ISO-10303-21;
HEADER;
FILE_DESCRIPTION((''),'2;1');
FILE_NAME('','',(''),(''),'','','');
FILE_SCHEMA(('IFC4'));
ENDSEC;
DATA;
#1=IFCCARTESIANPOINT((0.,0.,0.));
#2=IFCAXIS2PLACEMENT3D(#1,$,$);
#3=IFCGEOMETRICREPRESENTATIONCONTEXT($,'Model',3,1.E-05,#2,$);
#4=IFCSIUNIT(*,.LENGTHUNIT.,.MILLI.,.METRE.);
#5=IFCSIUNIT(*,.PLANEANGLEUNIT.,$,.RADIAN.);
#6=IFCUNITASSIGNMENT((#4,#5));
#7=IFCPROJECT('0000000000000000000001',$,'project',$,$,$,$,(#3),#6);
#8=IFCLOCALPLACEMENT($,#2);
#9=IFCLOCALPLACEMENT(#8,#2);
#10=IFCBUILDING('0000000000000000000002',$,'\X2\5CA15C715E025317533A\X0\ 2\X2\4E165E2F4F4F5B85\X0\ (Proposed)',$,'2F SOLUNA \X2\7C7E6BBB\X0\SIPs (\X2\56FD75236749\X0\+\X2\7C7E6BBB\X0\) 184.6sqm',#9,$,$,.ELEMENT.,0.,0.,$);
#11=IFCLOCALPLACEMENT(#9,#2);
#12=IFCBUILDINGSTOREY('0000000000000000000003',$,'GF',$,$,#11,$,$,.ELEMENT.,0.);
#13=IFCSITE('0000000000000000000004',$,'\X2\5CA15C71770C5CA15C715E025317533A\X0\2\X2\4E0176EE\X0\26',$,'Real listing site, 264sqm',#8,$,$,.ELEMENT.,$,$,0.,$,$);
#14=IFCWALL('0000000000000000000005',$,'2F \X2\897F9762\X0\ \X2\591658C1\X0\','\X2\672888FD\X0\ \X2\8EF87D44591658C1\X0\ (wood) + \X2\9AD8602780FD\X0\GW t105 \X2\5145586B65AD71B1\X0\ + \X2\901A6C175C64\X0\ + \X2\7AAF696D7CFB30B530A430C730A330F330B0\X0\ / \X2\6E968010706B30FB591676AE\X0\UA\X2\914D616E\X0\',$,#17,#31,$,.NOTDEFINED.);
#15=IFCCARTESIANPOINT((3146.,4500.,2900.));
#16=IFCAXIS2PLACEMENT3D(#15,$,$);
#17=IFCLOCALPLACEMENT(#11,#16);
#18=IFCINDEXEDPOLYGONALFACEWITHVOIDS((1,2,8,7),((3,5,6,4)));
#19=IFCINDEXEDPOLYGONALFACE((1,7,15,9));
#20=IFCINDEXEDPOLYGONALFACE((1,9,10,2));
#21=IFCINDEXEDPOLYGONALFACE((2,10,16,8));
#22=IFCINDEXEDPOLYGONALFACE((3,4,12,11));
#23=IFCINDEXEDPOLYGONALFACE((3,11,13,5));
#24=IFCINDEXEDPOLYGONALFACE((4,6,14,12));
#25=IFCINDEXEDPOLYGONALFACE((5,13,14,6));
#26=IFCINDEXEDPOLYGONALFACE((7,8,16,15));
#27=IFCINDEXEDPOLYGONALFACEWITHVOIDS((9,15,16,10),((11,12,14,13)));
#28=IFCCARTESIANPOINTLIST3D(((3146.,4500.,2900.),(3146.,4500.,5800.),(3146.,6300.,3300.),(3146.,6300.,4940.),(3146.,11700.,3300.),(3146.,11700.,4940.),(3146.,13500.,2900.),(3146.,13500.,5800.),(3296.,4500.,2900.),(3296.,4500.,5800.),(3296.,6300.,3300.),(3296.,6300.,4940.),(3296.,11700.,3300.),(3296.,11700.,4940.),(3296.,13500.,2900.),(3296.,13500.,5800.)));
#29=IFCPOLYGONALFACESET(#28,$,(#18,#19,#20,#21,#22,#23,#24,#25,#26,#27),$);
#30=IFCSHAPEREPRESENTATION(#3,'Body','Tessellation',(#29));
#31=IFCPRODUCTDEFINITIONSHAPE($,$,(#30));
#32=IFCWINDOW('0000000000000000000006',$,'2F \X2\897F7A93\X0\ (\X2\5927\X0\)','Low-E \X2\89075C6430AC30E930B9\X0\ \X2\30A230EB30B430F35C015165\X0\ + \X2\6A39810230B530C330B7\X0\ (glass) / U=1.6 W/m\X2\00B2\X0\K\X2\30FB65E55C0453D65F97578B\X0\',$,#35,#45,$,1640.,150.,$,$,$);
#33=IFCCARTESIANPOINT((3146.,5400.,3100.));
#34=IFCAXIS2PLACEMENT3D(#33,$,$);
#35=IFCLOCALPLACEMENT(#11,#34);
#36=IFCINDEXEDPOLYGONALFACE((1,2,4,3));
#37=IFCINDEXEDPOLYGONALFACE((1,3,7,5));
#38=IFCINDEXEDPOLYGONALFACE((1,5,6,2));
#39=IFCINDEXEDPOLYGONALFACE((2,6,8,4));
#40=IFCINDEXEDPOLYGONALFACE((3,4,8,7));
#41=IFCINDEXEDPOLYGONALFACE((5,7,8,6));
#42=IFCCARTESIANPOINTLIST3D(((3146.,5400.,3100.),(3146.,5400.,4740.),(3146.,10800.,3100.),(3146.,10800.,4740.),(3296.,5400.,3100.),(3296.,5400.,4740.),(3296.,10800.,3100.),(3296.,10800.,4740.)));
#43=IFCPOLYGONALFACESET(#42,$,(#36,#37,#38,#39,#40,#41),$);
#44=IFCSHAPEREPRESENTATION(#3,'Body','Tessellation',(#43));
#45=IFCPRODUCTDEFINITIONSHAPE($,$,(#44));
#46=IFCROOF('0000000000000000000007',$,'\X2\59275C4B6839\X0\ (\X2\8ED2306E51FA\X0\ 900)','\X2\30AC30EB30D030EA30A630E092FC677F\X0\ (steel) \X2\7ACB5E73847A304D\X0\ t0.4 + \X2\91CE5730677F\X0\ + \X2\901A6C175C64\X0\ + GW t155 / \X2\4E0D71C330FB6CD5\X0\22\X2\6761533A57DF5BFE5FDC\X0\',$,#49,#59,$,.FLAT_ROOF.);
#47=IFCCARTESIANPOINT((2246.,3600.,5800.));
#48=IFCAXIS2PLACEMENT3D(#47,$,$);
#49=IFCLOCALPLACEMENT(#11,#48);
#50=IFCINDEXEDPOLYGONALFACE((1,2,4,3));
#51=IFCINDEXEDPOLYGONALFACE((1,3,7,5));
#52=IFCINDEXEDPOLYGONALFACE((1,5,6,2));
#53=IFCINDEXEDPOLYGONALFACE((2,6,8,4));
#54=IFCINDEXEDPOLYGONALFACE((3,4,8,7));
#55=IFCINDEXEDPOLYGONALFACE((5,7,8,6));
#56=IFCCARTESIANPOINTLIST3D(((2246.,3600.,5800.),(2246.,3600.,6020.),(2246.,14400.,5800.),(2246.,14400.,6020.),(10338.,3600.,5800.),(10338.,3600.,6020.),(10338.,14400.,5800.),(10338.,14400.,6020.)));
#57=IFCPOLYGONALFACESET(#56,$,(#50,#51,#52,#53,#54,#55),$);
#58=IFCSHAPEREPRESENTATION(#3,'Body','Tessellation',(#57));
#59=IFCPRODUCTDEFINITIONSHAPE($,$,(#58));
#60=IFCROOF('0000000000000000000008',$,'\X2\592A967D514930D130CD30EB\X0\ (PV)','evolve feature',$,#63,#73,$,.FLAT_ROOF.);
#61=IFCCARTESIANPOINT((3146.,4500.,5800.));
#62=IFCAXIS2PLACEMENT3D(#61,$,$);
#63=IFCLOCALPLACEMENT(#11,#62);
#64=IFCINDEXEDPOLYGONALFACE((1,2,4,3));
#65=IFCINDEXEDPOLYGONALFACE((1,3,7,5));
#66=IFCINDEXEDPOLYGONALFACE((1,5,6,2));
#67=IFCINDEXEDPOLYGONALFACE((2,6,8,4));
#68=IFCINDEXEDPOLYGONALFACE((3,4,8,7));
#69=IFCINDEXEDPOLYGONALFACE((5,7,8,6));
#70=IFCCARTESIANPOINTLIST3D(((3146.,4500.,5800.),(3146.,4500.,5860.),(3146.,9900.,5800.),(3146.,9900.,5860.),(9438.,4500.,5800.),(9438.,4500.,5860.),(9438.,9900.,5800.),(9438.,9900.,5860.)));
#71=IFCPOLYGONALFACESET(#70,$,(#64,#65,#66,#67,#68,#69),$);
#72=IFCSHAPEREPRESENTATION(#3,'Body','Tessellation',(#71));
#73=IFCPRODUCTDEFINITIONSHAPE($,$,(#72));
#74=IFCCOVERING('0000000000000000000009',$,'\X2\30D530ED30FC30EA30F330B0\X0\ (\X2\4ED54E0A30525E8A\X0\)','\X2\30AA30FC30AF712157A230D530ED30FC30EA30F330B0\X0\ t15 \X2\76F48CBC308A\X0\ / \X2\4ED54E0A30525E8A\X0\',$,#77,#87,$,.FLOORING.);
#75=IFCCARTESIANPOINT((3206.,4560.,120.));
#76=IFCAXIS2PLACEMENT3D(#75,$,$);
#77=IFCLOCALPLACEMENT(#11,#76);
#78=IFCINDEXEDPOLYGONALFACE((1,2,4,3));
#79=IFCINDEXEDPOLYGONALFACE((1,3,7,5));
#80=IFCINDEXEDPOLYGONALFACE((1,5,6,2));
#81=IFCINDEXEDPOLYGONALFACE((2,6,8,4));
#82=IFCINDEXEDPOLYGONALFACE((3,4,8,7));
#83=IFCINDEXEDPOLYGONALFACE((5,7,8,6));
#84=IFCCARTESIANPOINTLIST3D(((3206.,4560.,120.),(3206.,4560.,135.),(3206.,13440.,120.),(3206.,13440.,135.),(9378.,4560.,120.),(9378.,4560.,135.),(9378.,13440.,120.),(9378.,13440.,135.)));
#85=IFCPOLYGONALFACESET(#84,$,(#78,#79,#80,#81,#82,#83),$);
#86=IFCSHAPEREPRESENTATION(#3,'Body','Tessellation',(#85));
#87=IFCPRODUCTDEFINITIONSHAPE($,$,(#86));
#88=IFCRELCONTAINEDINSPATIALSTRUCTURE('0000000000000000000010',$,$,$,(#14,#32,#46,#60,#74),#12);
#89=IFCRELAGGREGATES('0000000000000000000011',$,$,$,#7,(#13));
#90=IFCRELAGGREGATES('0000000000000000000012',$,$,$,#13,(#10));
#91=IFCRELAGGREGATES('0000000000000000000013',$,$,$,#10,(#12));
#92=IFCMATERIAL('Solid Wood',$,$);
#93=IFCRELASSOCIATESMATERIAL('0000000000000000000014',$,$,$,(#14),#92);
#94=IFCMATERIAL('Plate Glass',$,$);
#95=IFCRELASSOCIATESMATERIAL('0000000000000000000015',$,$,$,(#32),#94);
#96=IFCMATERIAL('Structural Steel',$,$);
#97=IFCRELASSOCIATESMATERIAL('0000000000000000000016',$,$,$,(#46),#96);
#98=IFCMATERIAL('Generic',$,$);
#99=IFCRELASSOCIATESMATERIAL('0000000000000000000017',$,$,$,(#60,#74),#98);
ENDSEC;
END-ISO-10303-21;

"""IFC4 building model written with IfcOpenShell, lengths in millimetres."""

from ifc_helpers import new_model, si_unit, frame, frame_2d, origin, place, context, project, spatial, rectangle, extrude, material, element, fill, save


model = new_model("IFC4")

# Units and contexts
model_context = context("Model", 3, precision=1e-05, world=origin())
ifc_project = project(units=[si_unit("LENGTHUNIT", "METRE", prefix="MILLI"), si_unit("PLANEANGLEUNIT", "RADIAN")], contexts=[model_context])

# Site, building, storey
site_placement = place(None, origin())
site = spatial("IfcSite", under=ifc_project, at=site_placement, Name="岡山県岡山市北区2丁目26", ObjectType="Real listing site, 264sqm", CompositionType="ELEMENT", RefElevation=0.0)
building_placement = place(site_placement, origin())
building = spatial("IfcBuilding", under=site, at=building_placement, Name="岡山市北区 2世帯住宅 (Proposed)", ObjectType="2F SOLUNA 籾殻SIPs (国産杉+籾殻) 184.6sqm", CompositionType="ELEMENT", ElevationOfRefHeight=0.0, ElevationOfTerrain=0.0)
storey_placement = place(building_placement, origin())
storey = spatial("IfcBuildingStorey", under=building, at=storey_placement, Name="GF", CompositionType="ELEMENT", Elevation=0.0)

# Shared definitions
ifc_material_1 = material(Name="Solid Wood")
ifc_material_2 = material(Name="Generic")

# Shared definitions
ifc_material_3 = material(Name="Plate Glass")

# Wall, opening, window
wall_1_placement = place(storey_placement, frame((3146.0, 4500.0, 2900.0)))
wall_1 = element("IfcWall", 1, at=wall_1_placement, inside=storey, material=ifc_material_1, Name="2F 西面 外壁", Description="木製 軸組外壁 (wood) + 高性能GW t105 充填断熱 + 通気層 + 窯業系サイディング / 準耐火・外皮UA配慮", PredefinedType="NOTDEFINED", context=model_context, shape_type="SweptSolid", body=[
    extrude(rectangle(XDim=150.0, YDim=9000.0, at=frame_2d((75.0, 4500.0))), frame((3146.0, 4500.0, 2900.0)), (0.0, 0.0, 1.0), 2900.0),
])
opening_1_placement = place(storey_placement, frame((3146.0, 5400.0, 3100.0)))
opening_1 = element("IfcOpeningElement", 2, at=opening_1_placement, cuts=wall_1, PredefinedType="NOTDEFINED", context=model_context, shape_type="SweptSolid", body=[
    extrude(rectangle(XDim=150.0, YDim=5400.0, at=frame_2d((75.0, 2700.0))), frame((3146.0, 5400.0, 3100.0)), (0.0, 0.0, 1.0), 1640.0),
])
window_1_placement = place(storey_placement, frame((3146.0, 5400.0, 3100.0)))
window_1 = element("IfcWindow", 3, at=window_1_placement, inside=storey, material=ifc_material_3, Name="2F 西窓 (大)", Description="Low-E 複層ガラス アルゴン封入 + 樹脂サッシ (glass) / U=1.6 W/m²K・日射取得型", OverallHeight=1640.0, OverallWidth=150.0, context=model_context, shape_type="SweptSolid", body=[
    extrude(rectangle(XDim=150.0, YDim=5400.0, at=frame_2d((75.0, 2700.0))), frame((3146.0, 5400.0, 3100.0)), (0.0, 0.0, 1.0), 1640.0),
])
fill(opening_1, window_1)

# Roofs
ifc_material_4 = material(Name="Structural Steel")
roof_1_placement = place(storey_placement, frame((2246.0, 3600.0, 5800.0)))
element("IfcRoof", 4, at=roof_1_placement, inside=storey, material=ifc_material_4, Name="大屋根 (軒の出 900)", Description="ガルバリウム鋼板 (steel) 立平葺き t0.4 + 野地板 + 通気層 + GW t155 / 不燃・法22条区域対応", PredefinedType="FLAT_ROOF", context=model_context, shape_type="SweptSolid", body=[
    extrude(rectangle(XDim=8092.0, YDim=10800.0, at=frame_2d((4046.0, 5400.0))), frame((2246.0, 3600.0, 5800.0)), (0.0, 0.0, 1.0), 220.0),
])
roof_2_placement = place(storey_placement, frame((3146.0, 4500.0, 5800.0)))
element("IfcRoof", 5, at=roof_2_placement, inside=storey, material=ifc_material_2, Name="太陽光パネル (PV)", Description="evolve feature", PredefinedType="FLAT_ROOF", context=model_context, shape_type="SweptSolid", body=[
    extrude(rectangle(XDim=6292.0, YDim=5400.0, at=frame_2d((3146.0, 2700.0))), frame((3146.0, 4500.0, 5800.0)), (0.0, 0.0, 1.0), 60.0),
])

# Covering
covering_placement = place(storey_placement, frame((3206.0, 4560.0, 120.0)))
element("IfcCovering", 6, at=covering_placement, inside=storey, material=ifc_material_2, Name="フローリング (仕上げ床)", Description="オーク無垢フローリング t15 直貼り / 仕上げ床", PredefinedType="FLOORING", context=model_context, shape_type="SweptSolid", body=[
    extrude(rectangle(XDim=6172.0, YDim=8880.0, at=frame_2d((3086.0, 4440.0))), frame((3206.0, 4560.0, 120.0)), (0.0, 0.0, 1.0), 15.0),
])

save(model, "model.ifc")
